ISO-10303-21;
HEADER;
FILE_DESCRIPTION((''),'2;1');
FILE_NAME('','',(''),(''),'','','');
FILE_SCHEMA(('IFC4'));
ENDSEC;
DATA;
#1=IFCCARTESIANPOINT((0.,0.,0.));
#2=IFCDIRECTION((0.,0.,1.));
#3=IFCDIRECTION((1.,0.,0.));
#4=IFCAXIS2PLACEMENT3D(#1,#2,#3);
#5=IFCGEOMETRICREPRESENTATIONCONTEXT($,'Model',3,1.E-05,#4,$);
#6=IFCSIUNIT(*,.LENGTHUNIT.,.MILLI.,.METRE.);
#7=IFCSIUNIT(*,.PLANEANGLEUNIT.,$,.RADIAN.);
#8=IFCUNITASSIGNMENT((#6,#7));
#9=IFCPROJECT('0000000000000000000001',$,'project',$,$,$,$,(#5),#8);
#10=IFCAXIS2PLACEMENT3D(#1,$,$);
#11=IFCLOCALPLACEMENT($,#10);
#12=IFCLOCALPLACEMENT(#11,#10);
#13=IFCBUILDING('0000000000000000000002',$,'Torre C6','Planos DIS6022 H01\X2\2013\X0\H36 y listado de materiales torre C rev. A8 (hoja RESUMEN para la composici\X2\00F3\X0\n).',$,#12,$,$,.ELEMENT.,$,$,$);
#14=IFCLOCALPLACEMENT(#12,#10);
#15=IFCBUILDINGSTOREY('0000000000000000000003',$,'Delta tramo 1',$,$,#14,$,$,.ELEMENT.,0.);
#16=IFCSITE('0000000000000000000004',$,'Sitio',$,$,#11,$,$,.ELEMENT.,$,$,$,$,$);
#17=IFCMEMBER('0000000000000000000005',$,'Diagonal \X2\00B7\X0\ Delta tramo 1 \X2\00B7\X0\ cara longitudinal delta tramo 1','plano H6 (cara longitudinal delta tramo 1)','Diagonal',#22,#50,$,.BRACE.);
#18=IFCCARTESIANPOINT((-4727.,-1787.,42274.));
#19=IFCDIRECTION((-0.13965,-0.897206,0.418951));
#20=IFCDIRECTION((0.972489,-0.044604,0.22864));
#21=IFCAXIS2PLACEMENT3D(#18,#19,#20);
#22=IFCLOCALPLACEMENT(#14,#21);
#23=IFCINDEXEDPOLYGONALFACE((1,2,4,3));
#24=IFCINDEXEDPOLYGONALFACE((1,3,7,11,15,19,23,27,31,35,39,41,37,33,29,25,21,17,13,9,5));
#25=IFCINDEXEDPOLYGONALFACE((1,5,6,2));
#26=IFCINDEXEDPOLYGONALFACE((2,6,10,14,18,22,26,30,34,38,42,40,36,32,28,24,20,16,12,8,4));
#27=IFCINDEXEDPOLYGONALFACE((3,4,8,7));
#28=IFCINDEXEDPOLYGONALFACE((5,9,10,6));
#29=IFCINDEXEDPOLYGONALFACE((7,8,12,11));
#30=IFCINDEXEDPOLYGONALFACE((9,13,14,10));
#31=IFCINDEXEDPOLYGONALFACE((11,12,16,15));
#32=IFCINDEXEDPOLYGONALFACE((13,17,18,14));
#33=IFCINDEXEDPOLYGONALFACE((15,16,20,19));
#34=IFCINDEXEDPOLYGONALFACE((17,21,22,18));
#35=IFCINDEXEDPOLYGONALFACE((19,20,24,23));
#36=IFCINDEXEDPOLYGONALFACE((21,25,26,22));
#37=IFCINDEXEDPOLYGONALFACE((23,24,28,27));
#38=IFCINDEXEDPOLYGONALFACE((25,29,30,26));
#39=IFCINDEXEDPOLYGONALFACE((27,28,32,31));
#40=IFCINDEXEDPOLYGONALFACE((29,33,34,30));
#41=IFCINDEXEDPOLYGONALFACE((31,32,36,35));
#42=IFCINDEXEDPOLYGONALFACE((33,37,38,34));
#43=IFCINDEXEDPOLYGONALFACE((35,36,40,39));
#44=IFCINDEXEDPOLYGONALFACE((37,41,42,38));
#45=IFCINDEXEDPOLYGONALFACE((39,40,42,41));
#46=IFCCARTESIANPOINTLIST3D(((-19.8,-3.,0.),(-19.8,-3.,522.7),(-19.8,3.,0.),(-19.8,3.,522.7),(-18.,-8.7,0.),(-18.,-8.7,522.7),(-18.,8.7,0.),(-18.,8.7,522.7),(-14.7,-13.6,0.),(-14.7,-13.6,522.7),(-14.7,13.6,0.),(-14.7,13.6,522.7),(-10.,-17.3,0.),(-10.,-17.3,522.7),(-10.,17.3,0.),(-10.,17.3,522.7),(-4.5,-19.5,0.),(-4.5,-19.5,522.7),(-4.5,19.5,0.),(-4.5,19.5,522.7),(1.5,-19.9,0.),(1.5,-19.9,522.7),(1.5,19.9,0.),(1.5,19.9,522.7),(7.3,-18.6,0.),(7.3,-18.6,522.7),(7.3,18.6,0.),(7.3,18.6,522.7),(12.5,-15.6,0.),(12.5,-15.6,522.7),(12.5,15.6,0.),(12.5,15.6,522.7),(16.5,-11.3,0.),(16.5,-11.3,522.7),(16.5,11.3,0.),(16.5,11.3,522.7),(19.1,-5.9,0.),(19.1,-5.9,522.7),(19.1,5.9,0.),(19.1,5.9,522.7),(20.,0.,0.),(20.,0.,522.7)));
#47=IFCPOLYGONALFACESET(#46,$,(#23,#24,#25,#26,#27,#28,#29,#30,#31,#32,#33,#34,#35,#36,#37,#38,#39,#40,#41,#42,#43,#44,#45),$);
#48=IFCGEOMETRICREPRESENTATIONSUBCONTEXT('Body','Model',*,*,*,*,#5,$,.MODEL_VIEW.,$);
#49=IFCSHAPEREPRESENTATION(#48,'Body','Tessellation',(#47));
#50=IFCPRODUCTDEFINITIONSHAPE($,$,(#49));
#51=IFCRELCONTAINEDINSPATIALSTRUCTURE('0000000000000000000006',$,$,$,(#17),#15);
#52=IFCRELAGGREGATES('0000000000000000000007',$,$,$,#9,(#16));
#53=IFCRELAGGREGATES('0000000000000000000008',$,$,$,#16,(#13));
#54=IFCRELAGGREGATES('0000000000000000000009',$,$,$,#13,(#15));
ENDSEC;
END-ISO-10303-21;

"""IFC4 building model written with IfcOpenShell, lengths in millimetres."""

from ifc_helpers import new_model, si_unit, frame, origin, origin_with_axes, place, context, subcontext, project, spatial, circle, extrude, element, save


model = new_model("IFC4")

# Units and contexts
model_context = context("Model", 3, precision=1e-05, world=origin_with_axes())
body_context = subcontext(model_context, "Body", "Model", "MODEL_VIEW")
ifc_project = project(units=[si_unit("LENGTHUNIT", "METRE", prefix="MILLI"), si_unit("PLANEANGLEUNIT", "RADIAN")], contexts=[model_context])

# Site, building, storey
site_placement = place(None, origin())
site = spatial("IfcSite", under=ifc_project, at=site_placement, Name="Sitio", CompositionType="ELEMENT")
building_placement = place(site_placement, origin())
building = spatial("IfcBuilding", under=site, at=building_placement, Name="Torre C6", Description="Planos DIS6022 H01–H36 y listado de materiales torre C rev. A8 (hoja RESUMEN para la composición).", CompositionType="ELEMENT")
storey_placement = place(building_placement, origin())
storey = spatial("IfcBuildingStorey", under=building, at=storey_placement, Name="Delta tramo 1", CompositionType="ELEMENT", Elevation=0.0)

# Member
member_1_placement = place(storey_placement, frame((-4727.0, -1787.0, 42274.0), z_axis=(-0.13965, -0.897206, 0.418951), x_axis=(0.972489, -0.044604, 0.22864)))
element("IfcMember", 1, at=member_1_placement, inside=storey, Name="Diagonal · Delta tramo 1 · cara longitudinal delta tramo 1", Description="plano H6 (cara longitudinal delta tramo 1)", ObjectType="Diagonal", PredefinedType="BRACE", context=body_context, shape_type="SweptSolid", body=[
    extrude(circle(Radius=20.0), None, (0.0, 0.0, 1.0), 522.7),
])

save(model, "model.ifc")
